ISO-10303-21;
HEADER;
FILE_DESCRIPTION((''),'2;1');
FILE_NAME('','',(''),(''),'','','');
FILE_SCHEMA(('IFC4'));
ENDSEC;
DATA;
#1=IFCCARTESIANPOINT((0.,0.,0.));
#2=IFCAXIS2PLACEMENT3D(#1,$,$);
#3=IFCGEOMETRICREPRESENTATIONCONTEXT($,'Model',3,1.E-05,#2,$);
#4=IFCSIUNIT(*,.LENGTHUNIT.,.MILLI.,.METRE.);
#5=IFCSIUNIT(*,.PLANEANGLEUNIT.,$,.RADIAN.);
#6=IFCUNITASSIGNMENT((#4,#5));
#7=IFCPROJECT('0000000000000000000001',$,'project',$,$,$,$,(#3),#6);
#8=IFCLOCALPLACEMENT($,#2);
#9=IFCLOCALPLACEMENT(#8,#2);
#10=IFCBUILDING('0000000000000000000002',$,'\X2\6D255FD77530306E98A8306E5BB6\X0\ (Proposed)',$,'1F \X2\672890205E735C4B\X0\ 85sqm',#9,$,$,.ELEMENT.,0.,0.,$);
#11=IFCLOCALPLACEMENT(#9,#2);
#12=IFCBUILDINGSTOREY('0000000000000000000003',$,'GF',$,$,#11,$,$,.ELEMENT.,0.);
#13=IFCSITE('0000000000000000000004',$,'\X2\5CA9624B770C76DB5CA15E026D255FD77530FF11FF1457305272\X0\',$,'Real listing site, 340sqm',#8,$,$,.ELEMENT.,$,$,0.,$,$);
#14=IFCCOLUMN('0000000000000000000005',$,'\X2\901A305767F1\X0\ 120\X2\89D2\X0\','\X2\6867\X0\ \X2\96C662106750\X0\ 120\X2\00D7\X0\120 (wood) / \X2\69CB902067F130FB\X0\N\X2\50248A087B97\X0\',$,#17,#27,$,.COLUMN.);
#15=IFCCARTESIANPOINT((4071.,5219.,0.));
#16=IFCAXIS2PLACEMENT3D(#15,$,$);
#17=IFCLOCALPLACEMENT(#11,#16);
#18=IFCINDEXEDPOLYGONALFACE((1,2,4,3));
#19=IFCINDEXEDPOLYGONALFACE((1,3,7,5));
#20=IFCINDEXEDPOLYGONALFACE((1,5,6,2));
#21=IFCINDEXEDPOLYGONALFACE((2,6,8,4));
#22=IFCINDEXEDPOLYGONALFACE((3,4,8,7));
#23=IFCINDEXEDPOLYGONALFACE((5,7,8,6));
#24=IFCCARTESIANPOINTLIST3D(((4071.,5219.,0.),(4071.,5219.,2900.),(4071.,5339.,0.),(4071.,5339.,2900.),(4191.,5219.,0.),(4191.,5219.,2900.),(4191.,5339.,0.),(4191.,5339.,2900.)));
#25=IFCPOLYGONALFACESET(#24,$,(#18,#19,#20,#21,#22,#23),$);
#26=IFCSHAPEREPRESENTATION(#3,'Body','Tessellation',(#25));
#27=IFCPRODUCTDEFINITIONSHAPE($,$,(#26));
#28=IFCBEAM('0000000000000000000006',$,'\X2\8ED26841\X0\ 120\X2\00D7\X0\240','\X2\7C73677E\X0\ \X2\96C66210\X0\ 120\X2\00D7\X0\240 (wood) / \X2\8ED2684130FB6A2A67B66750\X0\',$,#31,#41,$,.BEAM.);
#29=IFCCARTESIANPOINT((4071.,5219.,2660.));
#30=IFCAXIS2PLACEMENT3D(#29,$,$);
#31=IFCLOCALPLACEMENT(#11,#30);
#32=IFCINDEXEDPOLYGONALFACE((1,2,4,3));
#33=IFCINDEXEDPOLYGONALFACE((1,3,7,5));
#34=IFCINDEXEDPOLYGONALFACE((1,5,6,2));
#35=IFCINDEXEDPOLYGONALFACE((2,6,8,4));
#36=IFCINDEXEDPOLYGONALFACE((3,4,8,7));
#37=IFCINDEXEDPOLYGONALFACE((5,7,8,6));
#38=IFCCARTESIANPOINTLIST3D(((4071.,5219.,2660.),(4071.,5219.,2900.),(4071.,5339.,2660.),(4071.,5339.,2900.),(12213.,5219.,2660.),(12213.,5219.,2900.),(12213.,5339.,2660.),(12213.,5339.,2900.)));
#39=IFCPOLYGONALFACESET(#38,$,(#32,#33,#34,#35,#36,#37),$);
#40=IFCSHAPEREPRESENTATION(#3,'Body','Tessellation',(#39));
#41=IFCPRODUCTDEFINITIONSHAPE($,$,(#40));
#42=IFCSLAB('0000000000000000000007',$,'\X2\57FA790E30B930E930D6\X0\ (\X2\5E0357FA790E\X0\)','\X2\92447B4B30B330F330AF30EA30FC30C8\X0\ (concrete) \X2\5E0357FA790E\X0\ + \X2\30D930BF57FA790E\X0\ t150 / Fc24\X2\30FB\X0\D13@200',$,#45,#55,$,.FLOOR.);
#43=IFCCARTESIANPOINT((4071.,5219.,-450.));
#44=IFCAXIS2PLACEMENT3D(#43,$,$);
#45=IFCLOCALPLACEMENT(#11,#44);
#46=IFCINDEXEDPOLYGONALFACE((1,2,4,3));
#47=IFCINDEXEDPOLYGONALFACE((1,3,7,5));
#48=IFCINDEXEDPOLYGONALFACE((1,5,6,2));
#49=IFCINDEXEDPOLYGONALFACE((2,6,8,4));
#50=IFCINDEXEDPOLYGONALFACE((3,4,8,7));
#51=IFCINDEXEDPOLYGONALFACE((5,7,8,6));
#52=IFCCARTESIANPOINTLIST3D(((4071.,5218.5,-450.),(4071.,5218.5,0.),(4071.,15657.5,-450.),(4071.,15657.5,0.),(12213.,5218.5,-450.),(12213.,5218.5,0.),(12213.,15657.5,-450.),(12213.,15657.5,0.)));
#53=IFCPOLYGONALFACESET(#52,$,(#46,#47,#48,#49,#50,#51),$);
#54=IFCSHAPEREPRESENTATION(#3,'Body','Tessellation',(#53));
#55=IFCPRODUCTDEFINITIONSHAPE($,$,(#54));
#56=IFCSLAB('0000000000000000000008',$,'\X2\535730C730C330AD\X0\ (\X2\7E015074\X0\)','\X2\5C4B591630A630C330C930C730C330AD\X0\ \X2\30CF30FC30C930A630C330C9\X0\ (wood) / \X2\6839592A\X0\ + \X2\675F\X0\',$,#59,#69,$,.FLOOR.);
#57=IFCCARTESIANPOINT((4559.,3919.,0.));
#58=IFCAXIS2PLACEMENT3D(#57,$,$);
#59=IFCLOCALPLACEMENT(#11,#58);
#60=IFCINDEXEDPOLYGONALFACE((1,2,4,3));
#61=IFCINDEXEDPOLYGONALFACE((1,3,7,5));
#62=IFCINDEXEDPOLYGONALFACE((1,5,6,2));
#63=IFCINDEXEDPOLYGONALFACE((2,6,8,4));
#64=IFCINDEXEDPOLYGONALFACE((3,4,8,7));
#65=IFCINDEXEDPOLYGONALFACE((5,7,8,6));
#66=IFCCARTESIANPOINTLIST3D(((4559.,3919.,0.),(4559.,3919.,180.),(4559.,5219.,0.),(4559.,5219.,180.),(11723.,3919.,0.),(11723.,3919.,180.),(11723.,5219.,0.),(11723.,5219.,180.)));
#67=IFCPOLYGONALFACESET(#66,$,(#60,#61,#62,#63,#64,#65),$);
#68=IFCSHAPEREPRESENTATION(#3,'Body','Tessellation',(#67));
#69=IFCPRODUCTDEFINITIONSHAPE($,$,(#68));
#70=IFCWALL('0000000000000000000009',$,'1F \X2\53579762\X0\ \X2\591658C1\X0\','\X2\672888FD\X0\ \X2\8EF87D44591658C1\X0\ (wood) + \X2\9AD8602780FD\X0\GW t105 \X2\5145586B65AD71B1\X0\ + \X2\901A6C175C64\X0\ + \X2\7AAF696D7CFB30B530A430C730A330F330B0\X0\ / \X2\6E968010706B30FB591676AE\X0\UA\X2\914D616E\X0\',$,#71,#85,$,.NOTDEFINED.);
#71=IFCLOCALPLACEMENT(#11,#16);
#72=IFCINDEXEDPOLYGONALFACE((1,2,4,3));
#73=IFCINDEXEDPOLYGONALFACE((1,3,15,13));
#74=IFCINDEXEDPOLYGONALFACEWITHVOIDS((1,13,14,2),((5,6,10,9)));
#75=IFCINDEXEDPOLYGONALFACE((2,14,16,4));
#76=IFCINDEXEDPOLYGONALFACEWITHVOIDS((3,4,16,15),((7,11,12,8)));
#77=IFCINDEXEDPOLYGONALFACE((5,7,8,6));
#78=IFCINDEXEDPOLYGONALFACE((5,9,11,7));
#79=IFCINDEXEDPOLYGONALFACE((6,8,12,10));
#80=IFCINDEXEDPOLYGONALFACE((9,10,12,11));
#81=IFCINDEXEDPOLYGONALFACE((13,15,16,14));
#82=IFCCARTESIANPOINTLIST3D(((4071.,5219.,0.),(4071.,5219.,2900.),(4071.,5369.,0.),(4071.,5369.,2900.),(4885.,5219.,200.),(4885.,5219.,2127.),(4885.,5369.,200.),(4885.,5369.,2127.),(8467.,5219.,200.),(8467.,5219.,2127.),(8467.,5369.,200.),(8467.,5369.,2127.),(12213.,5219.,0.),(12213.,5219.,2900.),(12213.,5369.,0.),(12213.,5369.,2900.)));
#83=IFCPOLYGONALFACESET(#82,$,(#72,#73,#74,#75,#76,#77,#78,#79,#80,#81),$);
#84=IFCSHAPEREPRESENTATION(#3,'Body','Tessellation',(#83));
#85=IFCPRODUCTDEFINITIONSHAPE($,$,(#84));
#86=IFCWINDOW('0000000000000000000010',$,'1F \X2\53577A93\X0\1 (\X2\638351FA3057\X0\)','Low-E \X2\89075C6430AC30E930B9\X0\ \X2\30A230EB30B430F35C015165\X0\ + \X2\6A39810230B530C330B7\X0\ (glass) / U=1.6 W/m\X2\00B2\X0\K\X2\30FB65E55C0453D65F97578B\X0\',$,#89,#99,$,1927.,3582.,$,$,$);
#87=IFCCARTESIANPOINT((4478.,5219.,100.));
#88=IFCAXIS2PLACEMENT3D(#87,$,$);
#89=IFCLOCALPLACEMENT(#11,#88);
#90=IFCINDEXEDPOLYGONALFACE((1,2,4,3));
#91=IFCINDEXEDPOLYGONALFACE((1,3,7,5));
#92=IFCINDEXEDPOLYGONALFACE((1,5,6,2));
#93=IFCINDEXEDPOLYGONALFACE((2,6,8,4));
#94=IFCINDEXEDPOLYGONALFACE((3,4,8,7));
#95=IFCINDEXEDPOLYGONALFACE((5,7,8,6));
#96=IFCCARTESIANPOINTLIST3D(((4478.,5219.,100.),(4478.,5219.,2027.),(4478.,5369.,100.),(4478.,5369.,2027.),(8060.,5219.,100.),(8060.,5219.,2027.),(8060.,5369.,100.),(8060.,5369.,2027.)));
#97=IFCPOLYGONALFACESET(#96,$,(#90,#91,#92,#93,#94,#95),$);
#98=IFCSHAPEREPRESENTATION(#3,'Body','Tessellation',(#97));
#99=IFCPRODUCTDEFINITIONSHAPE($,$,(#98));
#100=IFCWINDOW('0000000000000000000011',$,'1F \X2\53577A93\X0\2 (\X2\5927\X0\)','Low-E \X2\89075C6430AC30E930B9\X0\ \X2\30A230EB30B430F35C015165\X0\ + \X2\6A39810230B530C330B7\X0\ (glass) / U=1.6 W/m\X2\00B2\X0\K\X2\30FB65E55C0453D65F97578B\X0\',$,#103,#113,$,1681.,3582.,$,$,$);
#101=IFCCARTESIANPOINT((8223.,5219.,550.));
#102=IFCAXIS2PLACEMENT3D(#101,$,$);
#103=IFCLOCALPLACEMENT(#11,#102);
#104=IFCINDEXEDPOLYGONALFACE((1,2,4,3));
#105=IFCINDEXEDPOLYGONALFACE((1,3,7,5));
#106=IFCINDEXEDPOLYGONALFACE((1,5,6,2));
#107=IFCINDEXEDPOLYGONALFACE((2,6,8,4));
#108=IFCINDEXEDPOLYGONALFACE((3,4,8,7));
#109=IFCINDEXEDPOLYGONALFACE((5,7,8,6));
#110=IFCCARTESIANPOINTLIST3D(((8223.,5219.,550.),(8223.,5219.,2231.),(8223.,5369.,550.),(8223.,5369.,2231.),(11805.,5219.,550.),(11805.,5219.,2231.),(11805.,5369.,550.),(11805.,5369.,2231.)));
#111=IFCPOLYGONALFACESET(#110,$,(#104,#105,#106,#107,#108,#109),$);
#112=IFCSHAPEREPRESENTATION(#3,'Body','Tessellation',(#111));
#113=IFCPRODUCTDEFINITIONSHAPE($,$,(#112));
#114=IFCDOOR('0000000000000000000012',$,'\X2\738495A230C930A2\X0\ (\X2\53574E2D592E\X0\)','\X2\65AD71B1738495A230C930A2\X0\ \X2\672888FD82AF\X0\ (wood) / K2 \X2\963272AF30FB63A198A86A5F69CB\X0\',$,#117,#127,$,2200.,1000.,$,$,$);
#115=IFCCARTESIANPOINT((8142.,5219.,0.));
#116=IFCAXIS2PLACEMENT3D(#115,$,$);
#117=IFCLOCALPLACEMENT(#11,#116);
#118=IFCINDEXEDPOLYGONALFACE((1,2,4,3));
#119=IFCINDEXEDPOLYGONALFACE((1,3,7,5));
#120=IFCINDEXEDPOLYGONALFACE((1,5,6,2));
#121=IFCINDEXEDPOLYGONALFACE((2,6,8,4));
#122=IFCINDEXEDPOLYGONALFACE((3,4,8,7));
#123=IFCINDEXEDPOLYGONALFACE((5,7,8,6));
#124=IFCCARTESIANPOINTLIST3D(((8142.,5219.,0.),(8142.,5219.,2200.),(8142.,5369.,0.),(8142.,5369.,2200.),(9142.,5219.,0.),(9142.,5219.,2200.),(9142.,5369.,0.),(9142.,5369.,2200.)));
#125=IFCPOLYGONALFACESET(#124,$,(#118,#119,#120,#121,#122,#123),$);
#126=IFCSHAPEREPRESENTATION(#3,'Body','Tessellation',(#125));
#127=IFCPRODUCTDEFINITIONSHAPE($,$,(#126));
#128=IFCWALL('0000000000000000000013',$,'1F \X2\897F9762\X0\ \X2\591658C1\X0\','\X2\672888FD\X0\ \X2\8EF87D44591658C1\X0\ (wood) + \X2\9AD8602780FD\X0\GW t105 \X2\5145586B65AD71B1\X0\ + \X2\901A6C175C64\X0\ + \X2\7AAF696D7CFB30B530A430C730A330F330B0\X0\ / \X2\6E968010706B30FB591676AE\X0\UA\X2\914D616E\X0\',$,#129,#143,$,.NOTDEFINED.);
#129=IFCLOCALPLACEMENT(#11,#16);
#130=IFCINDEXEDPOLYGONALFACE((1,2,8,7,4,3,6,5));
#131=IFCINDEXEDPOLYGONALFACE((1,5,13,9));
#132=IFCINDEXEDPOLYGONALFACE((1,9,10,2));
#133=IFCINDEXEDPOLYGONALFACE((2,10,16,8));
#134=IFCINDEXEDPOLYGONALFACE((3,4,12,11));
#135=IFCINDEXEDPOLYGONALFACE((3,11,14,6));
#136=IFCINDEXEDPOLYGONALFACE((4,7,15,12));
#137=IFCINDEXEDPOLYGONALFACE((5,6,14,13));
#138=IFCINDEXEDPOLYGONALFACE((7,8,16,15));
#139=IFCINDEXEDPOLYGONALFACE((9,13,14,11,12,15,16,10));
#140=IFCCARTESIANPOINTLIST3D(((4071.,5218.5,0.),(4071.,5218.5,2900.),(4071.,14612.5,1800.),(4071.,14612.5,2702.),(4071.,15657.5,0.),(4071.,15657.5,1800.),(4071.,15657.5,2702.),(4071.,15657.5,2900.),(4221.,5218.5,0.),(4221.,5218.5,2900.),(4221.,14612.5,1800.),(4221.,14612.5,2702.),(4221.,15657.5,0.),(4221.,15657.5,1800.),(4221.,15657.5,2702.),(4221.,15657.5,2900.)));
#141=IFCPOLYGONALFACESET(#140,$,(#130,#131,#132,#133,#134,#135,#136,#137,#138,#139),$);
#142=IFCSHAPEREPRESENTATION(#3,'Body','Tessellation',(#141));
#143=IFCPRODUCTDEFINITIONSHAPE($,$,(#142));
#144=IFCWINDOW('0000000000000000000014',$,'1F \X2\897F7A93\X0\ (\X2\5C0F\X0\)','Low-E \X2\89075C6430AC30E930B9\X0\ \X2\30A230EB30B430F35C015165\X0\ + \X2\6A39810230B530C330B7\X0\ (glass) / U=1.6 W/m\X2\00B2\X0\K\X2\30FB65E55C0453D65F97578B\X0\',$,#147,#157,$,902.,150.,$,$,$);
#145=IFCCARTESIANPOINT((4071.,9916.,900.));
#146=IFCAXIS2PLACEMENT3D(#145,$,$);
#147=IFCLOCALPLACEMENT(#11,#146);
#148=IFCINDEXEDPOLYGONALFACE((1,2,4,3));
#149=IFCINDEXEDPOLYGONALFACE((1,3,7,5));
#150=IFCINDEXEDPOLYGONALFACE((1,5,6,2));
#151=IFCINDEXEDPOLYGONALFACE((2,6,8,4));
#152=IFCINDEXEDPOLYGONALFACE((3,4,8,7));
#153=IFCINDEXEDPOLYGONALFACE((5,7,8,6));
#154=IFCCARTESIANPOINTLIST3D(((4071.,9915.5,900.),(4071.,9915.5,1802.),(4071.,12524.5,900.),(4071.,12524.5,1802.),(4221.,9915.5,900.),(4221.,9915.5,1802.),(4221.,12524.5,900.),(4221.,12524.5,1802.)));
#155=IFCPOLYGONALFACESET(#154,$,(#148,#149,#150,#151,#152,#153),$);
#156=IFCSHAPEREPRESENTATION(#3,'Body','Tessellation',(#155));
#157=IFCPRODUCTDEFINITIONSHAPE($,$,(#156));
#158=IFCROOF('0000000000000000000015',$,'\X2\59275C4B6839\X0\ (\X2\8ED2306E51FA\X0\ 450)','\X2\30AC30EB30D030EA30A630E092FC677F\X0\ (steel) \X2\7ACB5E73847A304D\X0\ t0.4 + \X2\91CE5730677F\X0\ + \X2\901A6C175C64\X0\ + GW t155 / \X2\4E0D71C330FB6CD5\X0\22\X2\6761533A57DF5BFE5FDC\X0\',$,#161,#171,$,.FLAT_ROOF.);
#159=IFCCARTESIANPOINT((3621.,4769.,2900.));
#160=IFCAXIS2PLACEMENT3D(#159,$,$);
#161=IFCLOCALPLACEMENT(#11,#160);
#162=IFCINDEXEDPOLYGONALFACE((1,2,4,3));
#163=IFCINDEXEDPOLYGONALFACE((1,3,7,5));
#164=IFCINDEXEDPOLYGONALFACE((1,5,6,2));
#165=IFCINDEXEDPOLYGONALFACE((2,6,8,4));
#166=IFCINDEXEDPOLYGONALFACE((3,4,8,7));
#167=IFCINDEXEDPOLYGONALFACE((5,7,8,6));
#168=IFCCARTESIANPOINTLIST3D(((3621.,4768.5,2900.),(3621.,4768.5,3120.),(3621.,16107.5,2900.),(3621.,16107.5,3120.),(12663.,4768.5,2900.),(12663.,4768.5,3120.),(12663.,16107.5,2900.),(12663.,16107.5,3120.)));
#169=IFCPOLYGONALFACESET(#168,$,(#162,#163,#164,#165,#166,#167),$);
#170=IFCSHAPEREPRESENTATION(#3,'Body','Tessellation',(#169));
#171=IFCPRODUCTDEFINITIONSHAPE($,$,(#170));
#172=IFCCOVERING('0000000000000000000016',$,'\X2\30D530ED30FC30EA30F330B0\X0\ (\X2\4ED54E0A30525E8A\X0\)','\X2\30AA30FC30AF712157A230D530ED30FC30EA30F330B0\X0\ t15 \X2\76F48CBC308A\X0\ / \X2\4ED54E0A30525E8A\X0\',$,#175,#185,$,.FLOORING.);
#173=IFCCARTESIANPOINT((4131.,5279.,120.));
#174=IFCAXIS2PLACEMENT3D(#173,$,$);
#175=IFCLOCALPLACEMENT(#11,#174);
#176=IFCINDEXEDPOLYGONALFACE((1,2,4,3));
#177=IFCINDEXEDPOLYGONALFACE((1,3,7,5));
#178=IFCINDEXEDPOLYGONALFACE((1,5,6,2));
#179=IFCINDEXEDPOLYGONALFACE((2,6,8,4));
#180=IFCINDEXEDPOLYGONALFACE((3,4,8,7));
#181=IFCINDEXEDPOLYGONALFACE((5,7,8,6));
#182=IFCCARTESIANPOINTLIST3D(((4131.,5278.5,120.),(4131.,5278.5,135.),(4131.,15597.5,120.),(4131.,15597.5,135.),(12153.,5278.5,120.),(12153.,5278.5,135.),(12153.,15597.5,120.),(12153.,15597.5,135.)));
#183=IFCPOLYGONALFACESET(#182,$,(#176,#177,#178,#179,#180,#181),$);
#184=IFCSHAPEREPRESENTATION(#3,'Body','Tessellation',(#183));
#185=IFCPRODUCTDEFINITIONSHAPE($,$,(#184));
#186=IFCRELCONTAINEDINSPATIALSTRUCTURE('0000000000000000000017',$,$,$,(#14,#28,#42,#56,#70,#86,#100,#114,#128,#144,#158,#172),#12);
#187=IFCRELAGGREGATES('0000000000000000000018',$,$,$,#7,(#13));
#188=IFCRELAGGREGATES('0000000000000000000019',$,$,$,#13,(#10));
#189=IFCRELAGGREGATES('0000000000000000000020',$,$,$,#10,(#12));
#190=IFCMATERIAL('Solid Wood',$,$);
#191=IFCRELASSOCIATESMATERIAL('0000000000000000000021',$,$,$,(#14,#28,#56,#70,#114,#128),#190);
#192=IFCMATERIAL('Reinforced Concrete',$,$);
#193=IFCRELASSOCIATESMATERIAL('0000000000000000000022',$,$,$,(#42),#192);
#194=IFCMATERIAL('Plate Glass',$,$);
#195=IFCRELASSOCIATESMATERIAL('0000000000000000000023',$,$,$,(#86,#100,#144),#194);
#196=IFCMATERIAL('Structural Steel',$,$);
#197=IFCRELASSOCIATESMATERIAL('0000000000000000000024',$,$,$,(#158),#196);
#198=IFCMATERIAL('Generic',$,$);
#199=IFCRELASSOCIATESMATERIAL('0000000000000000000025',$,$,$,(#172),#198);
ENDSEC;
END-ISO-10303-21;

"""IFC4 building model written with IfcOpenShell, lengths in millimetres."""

from ifc_helpers import new_model, si_unit, frame, frame_2d, origin, place, context, project, spatial, rectangle, extrude, material, element, fill, save


model = new_model("IFC4")

# Units and contexts
model_context = context("Model", 3, precision=1e-05, world=origin())
ifc_project = project(units=[si_unit("LENGTHUNIT", "METRE", prefix="MILLI"), si_unit("PLANEANGLEUNIT", "RADIAN")], contexts=[model_context])

# Site, building, storey
site_placement = place(None, origin())
site = spatial("IfcSite", under=ifc_project, at=site_placement, Name="岩手県盛岡市津志田１４地割", ObjectType="Real listing site, 340sqm", CompositionType="ELEMENT", RefElevation=0.0)
building_placement = place(site_placement, origin())
building = spatial("IfcBuilding", under=site, at=building_placement, Name="津志田の風の家 (Proposed)", ObjectType="1F 木造平屋 85sqm", CompositionType="ELEMENT", ElevationOfRefHeight=0.0, ElevationOfTerrain=0.0)
storey_placement = place(building_placement, origin())
storey = spatial("IfcBuildingStorey", under=building, at=storey_placement, Name="GF", CompositionType="ELEMENT", Elevation=0.0)

# Column
ifc_material_1 = material(Name="Solid Wood")
column_1_placement = place(storey_placement, frame((4071.0, 5219.0, 0.0)))
element("IfcColumn", 1, at=column_1_placement, inside=storey, material=ifc_material_1, Name="通し柱 120角", Description="桧 集成材 120×120 (wood) / 構造柱・N値計算", PredefinedType="COLUMN", context=model_context, shape_type="SweptSolid", body=[
    extrude(rectangle(XDim=120.0, YDim=120.0, at=frame_2d((60.0, 60.0))), frame((4071.0, 5219.0, 0.0)), (0.0, 0.0, 1.0), 2900.0),
])

# Beam
beam_1_placement = place(storey_placement, frame((4071.0, 5219.0, 2660.0)))
element("IfcBeam", 2, at=beam_1_placement, inside=storey, material=ifc_material_1, Name="軒桁 120×240", Description="米松 集成 120×240 (wood) / 軒桁・横架材", PredefinedType="BEAM", context=model_context, shape_type="SweptSolid", body=[
    extrude(rectangle(XDim=8142.0, YDim=120.0, at=frame_2d((4071.0, 60.0))), frame((4071.0, 5219.0, 2660.0)), (0.0, 0.0, 1.0), 240.0),
])

# Slabs
ifc_material_2 = material(Name="Reinforced Concrete")
slab_1_placement = place(storey_placement, frame((4071.0, 5219.0, -450.0)))
element("IfcSlab", 3, at=slab_1_placement, inside=storey, material=ifc_material_2, Name="基礎スラブ (布基礎)", Description="鉄筋コンクリート (concrete) 布基礎 + ベタ基礎 t150 / Fc24・D13@200", PredefinedType="FLOOR", context=model_context, shape_type="SweptSolid", body=[
    extrude(rectangle(XDim=8142.0, YDim=10439.0, at=frame_2d((4071.0, 5219.0))), frame((4071.0, 5219.0, -450.0)), (0.0, 0.0, 1.0), 450.0),
])
slab_2_placement = place(storey_placement, frame((4559.0, 3919.0, 0.0)))
element("IfcSlab", 4, at=slab_2_placement, inside=storey, material=ifc_material_1, Name="南デッキ (縁側)", Description="屋外ウッドデッキ ハードウッド (wood) / 根太 + 束", PredefinedType="FLOOR", context=model_context, shape_type="SweptSolid", body=[
    extrude(rectangle(XDim=7164.0, YDim=1300.0, at=frame_2d((3582.0, 650.0))), frame((4559.0, 3919.0, 0.0)), (0.0, 0.0, 1.0), 180.0),
])

# Wall, openings, windows, door
wall_1_placement = place(storey_placement, frame((4071.0, 5219.0, 0.0)))
wall_1 = element("IfcWall", 5, at=wall_1_placement, inside=storey, material=ifc_material_1, Name="1F 南面 外壁", Description="木製 軸組外壁 (wood) + 高性能GW t105 充填断熱 + 通気層 + 窯業系サイディング / 準耐火・外皮UA配慮", PredefinedType="NOTDEFINED", context=model_context, shape_type="SweptSolid", body=[
    extrude(rectangle(XDim=8142.0, YDim=150.0, at=frame_2d((4071.0, 75.0))), frame((4071.0, 5219.0, 0.0)), (0.0, 0.0, 1.0), 2900.0),
])
opening_1_placement = place(storey_placement, frame((4478.0, 5219.0, 100.0)))
opening_1 = element("IfcOpeningElement", 6, at=opening_1_placement, cuts=wall_1, PredefinedType="NOTDEFINED", context=model_context, shape_type="SweptSolid", body=[
    extrude(rectangle(XDim=3582.0, YDim=150.0, at=frame_2d((1791.0, 75.0))), frame((4478.0, 5219.0, 100.0)), (0.0, 0.0, 1.0), 1927.0),
])
opening_2_placement = place(storey_placement, frame((8223.0, 5219.0, 550.0)))
opening_2 = element("IfcOpeningElement", 7, at=opening_2_placement, cuts=wall_1, PredefinedType="NOTDEFINED", context=model_context, shape_type="SweptSolid", body=[
    extrude(rectangle(XDim=3582.0, YDim=150.0, at=frame_2d((1791.0, 75.0))), frame((8223.0, 5219.0, 550.0)), (0.0, 0.0, 1.0), 1681.0),
])
opening_3_placement = place(storey_placement, frame((8142.0, 5219.0, 0.0)))
opening_3 = element("IfcOpeningElement", 8, at=opening_3_placement, cuts=wall_1, PredefinedType="NOTDEFINED", context=model_context, shape_type="SweptSolid", body=[
    extrude(rectangle(XDim=1000.0, YDim=150.0, at=frame_2d((500.0, 75.0))), frame((8142.0, 5219.0, 0.0)), (0.0, 0.0, 1.0), 2200.0),
])
ifc_material_3 = material(Name="Plate Glass")
window_1_placement = place(storey_placement, frame((4478.0, 5219.0, 100.0)))
window_1 = element("IfcWindow", 9, at=window_1_placement, inside=storey, material=ifc_material_3, Name="1F 南窓1 (掃出し)", Description="Low-E 複層ガラス アルゴン封入 + 樹脂サッシ (glass) / U=1.6 W/m²K・日射取得型", OverallHeight=1927.0, OverallWidth=3582.0, context=model_context, shape_type="SweptSolid", body=[
    extrude(rectangle(XDim=3582.0, YDim=150.0, at=frame_2d((1791.0, 75.0))), frame((4478.0, 5219.0, 100.0)), (0.0, 0.0, 1.0), 1927.0),
])
fill(opening_1, window_1)
window_2_placement = place(storey_placement, frame((8223.0, 5219.0, 550.0)))
window_2 = element("IfcWindow", 10, at=window_2_placement, inside=storey, material=ifc_material_3, Name="1F 南窓2 (大)", Description="Low-E 複層ガラス アルゴン封入 + 樹脂サッシ (glass) / U=1.6 W/m²K・日射取得型", OverallHeight=1681.0, OverallWidth=3582.0, context=model_context, shape_type="SweptSolid", body=[
    extrude(rectangle(XDim=3582.0, YDim=150.0, at=frame_2d((1791.0, 75.0))), frame((8223.0, 5219.0, 550.0)), (0.0, 0.0, 1.0), 1681.0),
])
fill(opening_2, window_2)
door_placement = place(storey_placement, frame((8142.0, 5219.0, 0.0)))
door = element("IfcDoor", 11, at=door_placement, inside=storey, material=ifc_material_1, Name="玄関ドア (南中央)", Description="断熱玄関ドア 木製芯 (wood) / K2 防犯・採風機構", OverallHeight=2200.0, OverallWidth=1000.0, context=model_context, shape_type="SweptSolid", body=[
    extrude(rectangle(XDim=1000.0, YDim=150.0, at=frame_2d((500.0, 75.0))), frame((8142.0, 5219.0, 0.0)), (0.0, 0.0, 1.0), 2200.0),
])
fill(opening_3, door)

# Wall, opening, window
wall_2_placement = place(storey_placement, frame((4071.0, 5219.0, 0.0)))
wall_2 = element("IfcWall", 12, at=wall_2_placement, inside=storey, material=ifc_material_1, Name="1F 西面 外壁", Description="木製 軸組外壁 (wood) + 高性能GW t105 充填断熱 + 通気層 + 窯業系サイディング / 準耐火・外皮UA配慮", PredefinedType="NOTDEFINED", context=model_context, shape_type="SweptSolid", body=[
    extrude(rectangle(XDim=150.0, YDim=10439.0, at=frame_2d((75.0, 5219.0))), frame((4071.0, 5219.0, 0.0)), (0.0, 0.0, 1.0), 2900.0),
])
opening_4_placement = place(storey_placement, frame((4071.0, 9916.0, 900.0)))
opening_4 = element("IfcOpeningElement", 13, at=opening_4_placement, cuts=wall_2, PredefinedType="NOTDEFINED", context=model_context, shape_type="SweptSolid", body=[
    extrude(rectangle(XDim=150.0, YDim=2609.0, at=frame_2d((75.0, 1304.0))), frame((4071.0, 9916.0, 900.0)), (0.0, 0.0, 1.0), 902.0),
])
window_3_placement = place(storey_placement, frame((4071.0, 9916.0, 900.0)))
window_3 = element("IfcWindow", 14, at=window_3_placement, inside=storey, material=ifc_material_3, Name="1F 西窓 (小)", Description="Low-E 複層ガラス アルゴン封入 + 樹脂サッシ (glass) / U=1.6 W/m²K・日射取得型", OverallHeight=902.0, OverallWidth=150.0, context=model_context, shape_type="SweptSolid", body=[
    extrude(rectangle(XDim=150.0, YDim=2609.0, at=frame_2d((75.0, 1304.0))), frame((4071.0, 9916.0, 900.0)), (0.0, 0.0, 1.0), 902.0),
])
fill(opening_4, window_3)

# Roof
ifc_material_4 = material(Name="Structural Steel")
roof_placement = place(storey_placement, frame((3621.0, 4769.0, 2900.0)))
element("IfcRoof", 15, at=roof_placement, inside=storey, material=ifc_material_4, Name="大屋根 (軒の出 450)", Description="ガルバリウム鋼板 (steel) 立平葺き t0.4 + 野地板 + 通気層 + GW t155 / 不燃・法22条区域対応", PredefinedType="FLAT_ROOF", context=model_context, shape_type="SweptSolid", body=[
    extrude(rectangle(XDim=9042.0, YDim=11339.0, at=frame_2d((4521.0, 5669.0))), frame((3621.0, 4769.0, 2900.0)), (0.0, 0.0, 1.0), 220.0),
])

# Covering
ifc_material_5 = material(Name="Generic")
covering_1_placement = place(storey_placement, frame((4131.0, 5279.0, 120.0)))
element("IfcCovering", 16, at=covering_1_placement, inside=storey, material=ifc_material_5, Name="フローリング (仕上げ床)", Description="オーク無垢フローリング t15 直貼り / 仕上げ床", PredefinedType="FLOORING", context=model_context, shape_type="SweptSolid", body=[
    extrude(rectangle(XDim=8022.0, YDim=10319.0, at=frame_2d((4011.0, 5159.0))), frame((4131.0, 5279.0, 120.0)), (0.0, 0.0, 1.0), 15.0),
])

save(model, "model.ifc")
